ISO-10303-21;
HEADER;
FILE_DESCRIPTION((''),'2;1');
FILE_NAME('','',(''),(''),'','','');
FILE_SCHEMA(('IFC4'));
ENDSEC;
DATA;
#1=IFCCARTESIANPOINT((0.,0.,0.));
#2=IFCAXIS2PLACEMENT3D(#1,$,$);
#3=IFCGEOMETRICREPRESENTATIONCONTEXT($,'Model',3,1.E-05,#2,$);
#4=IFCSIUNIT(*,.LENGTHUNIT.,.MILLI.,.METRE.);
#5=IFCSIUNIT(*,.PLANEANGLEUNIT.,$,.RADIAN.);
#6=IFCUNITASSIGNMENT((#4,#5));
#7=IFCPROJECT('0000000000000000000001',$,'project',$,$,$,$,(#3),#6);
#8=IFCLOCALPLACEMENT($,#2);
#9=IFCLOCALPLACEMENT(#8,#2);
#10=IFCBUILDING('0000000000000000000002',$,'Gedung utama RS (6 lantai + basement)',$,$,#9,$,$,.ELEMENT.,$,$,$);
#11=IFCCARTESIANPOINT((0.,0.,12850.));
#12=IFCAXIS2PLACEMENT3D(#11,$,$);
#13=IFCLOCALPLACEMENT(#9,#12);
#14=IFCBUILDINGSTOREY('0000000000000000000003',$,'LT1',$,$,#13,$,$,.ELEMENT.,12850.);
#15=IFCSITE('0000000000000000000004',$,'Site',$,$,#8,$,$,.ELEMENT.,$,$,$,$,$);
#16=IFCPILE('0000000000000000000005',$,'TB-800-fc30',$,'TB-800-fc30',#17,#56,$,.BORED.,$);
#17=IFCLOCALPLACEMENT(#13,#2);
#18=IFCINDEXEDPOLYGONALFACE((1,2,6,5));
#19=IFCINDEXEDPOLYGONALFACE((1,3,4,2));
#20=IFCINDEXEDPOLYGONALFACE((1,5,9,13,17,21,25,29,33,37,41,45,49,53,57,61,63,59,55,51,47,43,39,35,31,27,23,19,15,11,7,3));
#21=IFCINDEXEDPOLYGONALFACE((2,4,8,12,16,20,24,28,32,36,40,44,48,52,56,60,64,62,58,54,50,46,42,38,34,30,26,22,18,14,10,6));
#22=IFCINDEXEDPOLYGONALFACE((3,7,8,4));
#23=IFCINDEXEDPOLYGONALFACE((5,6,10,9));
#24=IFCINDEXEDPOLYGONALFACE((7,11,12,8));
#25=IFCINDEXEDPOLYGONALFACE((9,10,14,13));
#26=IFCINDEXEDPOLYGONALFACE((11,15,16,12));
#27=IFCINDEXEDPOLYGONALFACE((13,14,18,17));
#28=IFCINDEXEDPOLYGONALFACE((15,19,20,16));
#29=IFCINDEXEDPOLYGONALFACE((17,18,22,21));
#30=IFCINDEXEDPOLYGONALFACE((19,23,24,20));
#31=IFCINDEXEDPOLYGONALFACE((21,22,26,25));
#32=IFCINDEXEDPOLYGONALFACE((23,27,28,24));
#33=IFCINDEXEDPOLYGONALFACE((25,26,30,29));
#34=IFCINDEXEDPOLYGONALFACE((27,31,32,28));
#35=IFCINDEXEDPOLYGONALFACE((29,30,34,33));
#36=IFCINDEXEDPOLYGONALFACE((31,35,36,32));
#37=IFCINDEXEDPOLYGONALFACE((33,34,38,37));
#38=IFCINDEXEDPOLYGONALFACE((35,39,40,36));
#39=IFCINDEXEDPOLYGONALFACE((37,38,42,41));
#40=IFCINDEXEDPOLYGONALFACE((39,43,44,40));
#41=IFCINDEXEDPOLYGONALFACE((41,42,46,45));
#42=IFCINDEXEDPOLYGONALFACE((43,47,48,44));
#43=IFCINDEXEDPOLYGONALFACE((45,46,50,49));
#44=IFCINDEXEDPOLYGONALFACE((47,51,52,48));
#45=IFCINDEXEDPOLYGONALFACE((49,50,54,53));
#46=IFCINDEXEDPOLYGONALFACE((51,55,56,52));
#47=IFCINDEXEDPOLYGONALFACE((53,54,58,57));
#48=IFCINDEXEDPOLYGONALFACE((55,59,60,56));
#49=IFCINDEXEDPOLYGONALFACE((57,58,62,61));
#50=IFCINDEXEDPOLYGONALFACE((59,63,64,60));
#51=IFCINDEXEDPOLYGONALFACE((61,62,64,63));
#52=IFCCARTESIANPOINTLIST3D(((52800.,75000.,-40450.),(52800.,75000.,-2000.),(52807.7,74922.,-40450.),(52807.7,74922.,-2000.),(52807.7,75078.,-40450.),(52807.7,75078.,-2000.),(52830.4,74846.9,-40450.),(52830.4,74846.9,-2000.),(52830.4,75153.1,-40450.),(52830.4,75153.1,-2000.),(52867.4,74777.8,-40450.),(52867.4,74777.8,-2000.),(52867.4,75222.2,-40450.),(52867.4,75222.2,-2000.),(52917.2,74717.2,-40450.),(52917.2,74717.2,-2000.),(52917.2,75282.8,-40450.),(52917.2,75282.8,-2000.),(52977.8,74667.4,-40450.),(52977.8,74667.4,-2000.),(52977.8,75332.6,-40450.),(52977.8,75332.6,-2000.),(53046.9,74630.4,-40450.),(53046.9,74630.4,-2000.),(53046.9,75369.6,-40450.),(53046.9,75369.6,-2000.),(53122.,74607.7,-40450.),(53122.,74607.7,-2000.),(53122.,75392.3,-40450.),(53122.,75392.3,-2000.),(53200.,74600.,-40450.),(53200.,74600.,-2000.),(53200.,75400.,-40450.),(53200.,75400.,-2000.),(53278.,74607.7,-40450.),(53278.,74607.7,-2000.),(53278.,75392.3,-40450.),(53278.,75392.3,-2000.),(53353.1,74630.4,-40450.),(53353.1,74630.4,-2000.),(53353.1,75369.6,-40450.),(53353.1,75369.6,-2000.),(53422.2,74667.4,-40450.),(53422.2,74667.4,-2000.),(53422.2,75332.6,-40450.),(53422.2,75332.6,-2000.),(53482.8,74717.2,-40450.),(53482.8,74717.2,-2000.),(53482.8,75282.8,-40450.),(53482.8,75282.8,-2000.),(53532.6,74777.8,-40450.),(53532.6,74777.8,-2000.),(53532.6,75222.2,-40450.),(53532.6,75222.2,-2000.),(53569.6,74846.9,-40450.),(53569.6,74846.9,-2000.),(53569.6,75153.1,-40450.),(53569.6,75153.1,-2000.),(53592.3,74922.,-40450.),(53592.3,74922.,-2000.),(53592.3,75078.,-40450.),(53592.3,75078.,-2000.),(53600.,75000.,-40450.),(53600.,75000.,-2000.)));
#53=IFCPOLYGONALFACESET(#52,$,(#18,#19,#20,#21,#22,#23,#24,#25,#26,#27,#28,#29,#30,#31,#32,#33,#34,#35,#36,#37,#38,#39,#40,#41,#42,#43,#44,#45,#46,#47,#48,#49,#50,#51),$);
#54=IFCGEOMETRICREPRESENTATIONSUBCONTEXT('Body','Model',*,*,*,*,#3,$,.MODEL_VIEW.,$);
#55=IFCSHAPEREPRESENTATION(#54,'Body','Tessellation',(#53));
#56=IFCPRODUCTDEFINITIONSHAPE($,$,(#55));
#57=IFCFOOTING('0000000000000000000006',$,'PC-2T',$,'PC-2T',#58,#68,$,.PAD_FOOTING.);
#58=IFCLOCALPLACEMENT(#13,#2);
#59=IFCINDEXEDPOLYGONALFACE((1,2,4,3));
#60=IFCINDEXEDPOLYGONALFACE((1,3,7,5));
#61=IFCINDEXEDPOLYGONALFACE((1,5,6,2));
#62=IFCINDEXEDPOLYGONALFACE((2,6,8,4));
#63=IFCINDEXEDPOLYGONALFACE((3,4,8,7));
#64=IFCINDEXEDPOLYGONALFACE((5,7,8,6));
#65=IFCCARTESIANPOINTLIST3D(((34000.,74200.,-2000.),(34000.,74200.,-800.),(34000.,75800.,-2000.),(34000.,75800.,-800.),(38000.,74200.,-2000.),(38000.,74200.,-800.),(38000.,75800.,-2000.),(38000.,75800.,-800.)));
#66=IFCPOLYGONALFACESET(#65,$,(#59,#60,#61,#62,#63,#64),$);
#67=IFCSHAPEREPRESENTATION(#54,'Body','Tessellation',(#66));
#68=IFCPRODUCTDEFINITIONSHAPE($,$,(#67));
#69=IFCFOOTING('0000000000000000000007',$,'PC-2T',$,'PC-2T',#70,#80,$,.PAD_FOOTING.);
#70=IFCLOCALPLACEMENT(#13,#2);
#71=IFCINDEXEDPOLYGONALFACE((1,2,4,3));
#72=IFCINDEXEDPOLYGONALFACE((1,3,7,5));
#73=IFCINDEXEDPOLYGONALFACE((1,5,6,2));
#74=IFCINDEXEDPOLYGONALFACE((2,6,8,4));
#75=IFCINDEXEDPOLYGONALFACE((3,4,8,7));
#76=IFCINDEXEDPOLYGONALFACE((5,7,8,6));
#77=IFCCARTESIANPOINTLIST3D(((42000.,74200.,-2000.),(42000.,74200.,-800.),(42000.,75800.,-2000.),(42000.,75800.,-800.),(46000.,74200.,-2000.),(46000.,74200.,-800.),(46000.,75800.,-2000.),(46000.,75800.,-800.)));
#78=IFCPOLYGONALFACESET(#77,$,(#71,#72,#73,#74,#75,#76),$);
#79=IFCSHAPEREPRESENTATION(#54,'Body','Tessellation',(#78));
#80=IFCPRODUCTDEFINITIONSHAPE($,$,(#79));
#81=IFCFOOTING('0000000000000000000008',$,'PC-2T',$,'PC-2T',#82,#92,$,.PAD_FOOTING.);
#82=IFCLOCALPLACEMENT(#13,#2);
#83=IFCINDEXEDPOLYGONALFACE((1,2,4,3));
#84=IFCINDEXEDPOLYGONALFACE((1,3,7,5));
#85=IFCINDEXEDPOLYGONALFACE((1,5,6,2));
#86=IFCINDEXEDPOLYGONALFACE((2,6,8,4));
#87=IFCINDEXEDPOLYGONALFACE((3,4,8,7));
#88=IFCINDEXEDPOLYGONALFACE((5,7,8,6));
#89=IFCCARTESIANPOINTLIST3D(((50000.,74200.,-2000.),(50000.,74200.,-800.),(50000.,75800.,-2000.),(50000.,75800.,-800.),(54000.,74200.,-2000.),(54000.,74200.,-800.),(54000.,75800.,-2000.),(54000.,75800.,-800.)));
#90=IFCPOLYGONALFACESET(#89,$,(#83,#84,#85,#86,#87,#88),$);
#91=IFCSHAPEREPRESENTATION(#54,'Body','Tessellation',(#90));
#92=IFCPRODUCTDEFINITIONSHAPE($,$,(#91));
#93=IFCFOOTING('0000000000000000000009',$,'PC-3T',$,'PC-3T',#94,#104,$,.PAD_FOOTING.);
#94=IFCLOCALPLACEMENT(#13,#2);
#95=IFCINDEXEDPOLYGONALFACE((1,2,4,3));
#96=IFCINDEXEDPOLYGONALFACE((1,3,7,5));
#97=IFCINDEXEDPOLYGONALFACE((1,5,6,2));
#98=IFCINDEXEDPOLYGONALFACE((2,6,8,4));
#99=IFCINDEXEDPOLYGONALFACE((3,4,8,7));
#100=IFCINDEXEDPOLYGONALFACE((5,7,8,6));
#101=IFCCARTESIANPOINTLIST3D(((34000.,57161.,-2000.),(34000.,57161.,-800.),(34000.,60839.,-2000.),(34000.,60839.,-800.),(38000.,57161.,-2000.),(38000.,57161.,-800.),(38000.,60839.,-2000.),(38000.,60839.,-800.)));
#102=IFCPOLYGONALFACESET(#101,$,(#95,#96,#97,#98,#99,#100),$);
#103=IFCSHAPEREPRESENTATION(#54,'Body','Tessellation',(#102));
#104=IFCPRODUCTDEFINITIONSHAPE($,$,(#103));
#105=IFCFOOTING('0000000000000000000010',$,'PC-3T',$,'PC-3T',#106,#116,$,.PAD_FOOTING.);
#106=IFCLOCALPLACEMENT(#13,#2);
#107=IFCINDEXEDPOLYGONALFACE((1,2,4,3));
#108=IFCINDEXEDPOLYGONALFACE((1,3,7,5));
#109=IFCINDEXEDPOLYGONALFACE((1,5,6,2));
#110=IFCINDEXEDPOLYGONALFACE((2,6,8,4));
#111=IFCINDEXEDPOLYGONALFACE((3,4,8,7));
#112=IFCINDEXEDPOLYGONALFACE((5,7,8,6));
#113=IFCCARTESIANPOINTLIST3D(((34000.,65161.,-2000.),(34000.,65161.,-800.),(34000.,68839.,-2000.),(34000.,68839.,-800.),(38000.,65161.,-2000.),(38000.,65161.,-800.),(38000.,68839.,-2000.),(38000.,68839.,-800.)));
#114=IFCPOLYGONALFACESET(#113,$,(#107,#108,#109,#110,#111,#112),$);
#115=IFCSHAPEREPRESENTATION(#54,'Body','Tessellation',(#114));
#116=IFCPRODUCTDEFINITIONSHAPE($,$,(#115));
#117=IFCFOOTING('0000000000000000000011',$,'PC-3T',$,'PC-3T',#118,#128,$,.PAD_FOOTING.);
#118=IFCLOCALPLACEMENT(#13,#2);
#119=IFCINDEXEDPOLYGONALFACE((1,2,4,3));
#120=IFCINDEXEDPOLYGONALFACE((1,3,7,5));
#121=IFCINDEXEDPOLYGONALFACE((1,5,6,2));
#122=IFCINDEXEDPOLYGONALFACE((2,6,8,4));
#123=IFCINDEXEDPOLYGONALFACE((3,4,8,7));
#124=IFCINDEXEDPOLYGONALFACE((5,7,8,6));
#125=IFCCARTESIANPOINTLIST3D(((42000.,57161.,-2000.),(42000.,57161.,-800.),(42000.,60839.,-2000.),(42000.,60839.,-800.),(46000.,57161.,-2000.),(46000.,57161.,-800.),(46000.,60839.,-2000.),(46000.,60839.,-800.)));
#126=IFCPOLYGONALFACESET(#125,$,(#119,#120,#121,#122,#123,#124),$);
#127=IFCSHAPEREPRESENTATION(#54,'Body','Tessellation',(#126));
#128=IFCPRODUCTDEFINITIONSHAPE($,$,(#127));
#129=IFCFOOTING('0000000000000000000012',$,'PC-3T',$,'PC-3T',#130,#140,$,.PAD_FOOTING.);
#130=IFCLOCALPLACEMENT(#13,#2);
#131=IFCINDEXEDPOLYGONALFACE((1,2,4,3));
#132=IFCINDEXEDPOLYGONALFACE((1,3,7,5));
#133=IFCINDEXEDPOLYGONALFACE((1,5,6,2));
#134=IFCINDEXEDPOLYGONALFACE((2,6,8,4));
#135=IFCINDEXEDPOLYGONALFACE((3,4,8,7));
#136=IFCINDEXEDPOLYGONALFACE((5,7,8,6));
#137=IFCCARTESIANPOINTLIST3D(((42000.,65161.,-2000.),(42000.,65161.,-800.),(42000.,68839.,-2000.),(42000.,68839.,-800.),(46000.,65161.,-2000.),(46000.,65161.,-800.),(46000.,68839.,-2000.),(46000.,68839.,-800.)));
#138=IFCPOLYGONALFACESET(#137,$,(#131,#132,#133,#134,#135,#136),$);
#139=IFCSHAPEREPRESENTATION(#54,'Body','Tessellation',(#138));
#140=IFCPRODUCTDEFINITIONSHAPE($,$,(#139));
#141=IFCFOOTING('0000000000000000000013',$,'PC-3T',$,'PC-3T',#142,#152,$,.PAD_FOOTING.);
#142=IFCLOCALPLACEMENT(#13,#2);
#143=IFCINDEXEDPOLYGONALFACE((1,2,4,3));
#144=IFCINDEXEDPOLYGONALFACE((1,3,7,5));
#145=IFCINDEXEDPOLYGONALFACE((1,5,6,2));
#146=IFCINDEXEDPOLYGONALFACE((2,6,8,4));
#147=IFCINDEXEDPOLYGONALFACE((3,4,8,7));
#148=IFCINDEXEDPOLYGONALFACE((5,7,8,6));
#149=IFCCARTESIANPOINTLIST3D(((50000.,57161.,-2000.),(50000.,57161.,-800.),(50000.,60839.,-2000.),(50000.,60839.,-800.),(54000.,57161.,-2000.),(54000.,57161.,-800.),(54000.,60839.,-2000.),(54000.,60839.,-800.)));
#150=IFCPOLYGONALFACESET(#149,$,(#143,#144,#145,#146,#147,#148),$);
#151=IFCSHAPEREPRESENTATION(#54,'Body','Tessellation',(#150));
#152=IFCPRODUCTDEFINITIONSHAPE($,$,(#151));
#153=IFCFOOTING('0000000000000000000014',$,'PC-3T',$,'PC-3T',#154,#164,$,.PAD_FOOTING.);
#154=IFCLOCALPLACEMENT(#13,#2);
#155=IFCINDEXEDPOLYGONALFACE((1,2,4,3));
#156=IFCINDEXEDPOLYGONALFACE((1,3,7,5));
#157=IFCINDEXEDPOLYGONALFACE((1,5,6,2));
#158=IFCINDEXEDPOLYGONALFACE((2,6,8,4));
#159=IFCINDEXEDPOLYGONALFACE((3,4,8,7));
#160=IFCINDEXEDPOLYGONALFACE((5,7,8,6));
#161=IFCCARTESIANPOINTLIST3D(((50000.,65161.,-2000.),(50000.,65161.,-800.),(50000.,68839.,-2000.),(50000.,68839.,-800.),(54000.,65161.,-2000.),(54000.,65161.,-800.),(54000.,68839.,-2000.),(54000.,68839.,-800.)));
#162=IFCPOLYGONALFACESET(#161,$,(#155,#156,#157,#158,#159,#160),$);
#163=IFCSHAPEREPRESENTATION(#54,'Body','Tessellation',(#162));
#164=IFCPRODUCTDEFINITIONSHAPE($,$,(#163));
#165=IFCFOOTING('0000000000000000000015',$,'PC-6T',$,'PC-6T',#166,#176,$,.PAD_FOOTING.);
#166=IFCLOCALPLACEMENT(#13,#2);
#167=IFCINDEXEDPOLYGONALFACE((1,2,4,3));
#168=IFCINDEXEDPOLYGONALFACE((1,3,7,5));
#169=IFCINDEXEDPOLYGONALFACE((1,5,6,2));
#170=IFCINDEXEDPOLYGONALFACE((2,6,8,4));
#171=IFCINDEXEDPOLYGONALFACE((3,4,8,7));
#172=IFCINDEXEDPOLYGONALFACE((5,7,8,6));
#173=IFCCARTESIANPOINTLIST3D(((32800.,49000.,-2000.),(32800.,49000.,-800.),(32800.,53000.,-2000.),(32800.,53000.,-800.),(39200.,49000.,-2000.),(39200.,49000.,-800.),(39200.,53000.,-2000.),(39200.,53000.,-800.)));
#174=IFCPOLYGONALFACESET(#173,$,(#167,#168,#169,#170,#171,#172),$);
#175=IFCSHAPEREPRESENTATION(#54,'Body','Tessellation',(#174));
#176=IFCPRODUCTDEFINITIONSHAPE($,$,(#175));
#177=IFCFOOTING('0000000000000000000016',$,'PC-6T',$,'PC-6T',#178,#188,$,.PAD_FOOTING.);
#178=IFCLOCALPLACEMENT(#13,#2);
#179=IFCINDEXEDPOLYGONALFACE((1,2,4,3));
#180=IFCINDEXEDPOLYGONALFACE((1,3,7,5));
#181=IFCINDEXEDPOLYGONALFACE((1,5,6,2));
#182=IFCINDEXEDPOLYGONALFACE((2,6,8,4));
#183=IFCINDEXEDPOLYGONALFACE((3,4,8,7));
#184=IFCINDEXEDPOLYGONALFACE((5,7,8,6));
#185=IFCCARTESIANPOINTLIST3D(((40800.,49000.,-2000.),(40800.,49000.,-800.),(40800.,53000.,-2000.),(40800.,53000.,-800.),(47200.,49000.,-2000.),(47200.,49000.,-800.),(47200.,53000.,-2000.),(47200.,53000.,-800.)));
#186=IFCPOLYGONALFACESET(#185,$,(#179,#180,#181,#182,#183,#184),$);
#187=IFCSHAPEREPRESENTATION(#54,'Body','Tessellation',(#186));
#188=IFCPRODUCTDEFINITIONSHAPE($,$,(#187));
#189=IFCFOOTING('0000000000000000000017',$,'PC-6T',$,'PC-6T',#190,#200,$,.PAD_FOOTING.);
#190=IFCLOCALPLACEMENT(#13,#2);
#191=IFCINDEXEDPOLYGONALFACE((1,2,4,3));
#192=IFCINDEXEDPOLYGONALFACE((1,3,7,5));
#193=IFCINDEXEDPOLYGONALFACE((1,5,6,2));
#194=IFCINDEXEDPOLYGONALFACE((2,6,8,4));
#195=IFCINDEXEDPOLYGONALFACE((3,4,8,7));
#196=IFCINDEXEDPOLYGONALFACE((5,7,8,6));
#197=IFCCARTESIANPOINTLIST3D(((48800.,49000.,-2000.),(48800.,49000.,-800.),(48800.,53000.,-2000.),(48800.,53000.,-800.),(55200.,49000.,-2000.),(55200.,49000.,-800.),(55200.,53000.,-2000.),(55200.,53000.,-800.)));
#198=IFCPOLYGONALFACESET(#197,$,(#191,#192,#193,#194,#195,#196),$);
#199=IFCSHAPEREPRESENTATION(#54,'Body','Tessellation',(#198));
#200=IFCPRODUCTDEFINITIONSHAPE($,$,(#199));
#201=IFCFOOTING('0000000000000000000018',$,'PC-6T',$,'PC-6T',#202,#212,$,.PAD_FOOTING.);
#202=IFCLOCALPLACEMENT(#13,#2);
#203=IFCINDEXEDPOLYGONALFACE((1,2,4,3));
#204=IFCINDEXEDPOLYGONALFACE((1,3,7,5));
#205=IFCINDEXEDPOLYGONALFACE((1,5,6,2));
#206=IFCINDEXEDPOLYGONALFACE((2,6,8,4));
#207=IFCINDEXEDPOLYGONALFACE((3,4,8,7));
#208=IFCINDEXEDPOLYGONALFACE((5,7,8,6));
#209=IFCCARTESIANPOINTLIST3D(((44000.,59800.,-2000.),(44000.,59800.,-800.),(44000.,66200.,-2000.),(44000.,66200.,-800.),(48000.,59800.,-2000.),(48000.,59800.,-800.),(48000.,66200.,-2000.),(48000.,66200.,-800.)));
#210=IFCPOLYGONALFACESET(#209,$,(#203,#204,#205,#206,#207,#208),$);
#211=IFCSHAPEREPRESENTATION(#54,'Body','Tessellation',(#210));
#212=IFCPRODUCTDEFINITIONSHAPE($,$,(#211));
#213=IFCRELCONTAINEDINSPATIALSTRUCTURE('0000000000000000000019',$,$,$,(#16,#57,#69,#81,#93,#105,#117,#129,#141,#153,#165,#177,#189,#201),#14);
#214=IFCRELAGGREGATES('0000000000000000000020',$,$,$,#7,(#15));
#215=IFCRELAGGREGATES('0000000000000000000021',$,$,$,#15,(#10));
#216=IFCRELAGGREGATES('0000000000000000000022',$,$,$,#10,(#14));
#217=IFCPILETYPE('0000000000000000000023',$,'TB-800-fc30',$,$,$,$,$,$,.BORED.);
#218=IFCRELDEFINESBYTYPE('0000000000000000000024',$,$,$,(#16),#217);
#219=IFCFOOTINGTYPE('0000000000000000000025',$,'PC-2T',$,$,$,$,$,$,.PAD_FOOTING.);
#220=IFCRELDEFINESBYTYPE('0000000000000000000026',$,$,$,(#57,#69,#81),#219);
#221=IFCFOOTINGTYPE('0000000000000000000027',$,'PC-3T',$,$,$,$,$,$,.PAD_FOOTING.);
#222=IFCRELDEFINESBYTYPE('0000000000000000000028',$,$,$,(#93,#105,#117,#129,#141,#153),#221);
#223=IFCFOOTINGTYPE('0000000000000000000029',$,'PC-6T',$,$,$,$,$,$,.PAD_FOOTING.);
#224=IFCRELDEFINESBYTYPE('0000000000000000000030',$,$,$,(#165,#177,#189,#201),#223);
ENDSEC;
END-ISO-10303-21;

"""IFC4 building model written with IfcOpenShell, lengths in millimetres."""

from ifc_helpers import new_model, si_unit, frame, origin, origin_2d, place, context, subcontext, project, spatial, rectangle, circle, extrude, material_profile, profile_set, profile_usage, type_object, element, save


model = new_model("IFC4")

# Units and contexts
model_context = context("Model", 3, precision=1e-05, world=origin())
body_context = subcontext(model_context, "Body", "Model", "MODEL_VIEW")
ifc_project = project(units=[si_unit("LENGTHUNIT", "METRE", prefix="MILLI"), si_unit("PLANEANGLEUNIT", "RADIAN")], contexts=[model_context])

# Site, building, storey
site_placement = place(None, origin())
site = spatial("IfcSite", under=ifc_project, at=site_placement, Name="Site", CompositionType="ELEMENT")
building_placement = place(site_placement, origin())
building = spatial("IfcBuilding", under=site, at=building_placement, Name="Gedung utama RS (6 lantai + basement)", CompositionType="ELEMENT")
storey_placement = place(building_placement, frame((0.0, 0.0, 12850.0)))
storey = spatial("IfcBuildingStorey", under=building, at=storey_placement, Name="LT1", CompositionType="ELEMENT", Elevation=12850.0)

# Pile
ifc_material_profile_1 = material_profile(None, circle(Radius=400.0, at=origin_2d()), Name="TB-800-fc30")
ifc_profile_set_1 = profile_set([ifc_material_profile_1], Name="TB-800-fc30")
ifc_profile_usage_1 = profile_usage(ifc_profile_set_1, cardinal=5)
pile_type = type_object("IfcPileType", Name="TB-800-fc30", PredefinedType="BORED", material=ifc_profile_set_1)
for number, where, z_axis, x_axis, name in (
    (1, (53200.0, 75000.0, -40450.0), (0.0, 0.0, 1.0), (1.0, 0.0, 0.0), "TB-800-fc30"),
):
    element("IfcPile", number, at=place(storey_placement, frame(where, z_axis=z_axis, x_axis=x_axis)), inside=storey, type_object=pile_type, material=ifc_profile_usage_1, Name=name, ObjectType="TB-800-fc30", PredefinedType="BORED", context=body_context, shape_type="SweptSolid", body=[
        extrude(circle(Radius=400.0, at=origin_2d()), origin(), (0.0, 0.0, 1.0), 38450.0),
    ])

# Footings
ifc_material_profile_2 = material_profile(None, rectangle(XDim=4000.0, YDim=1600.0, at=origin_2d()), Name="PC-2T")
ifc_profile_set_2 = profile_set([ifc_material_profile_2], Name="PC-2T")
ifc_profile_usage_2 = profile_usage(ifc_profile_set_2, cardinal=5)
footing_type_1 = type_object("IfcFootingType", Name="PC-2T", PredefinedType="PAD_FOOTING", material=ifc_profile_set_2)
for number, where, z_axis, x_axis, name in (
    (2, (36000.0, 75000.0, -2000.0), (0.0, 0.0, 1.0), (1.0, 0.0, 0.0), "PC-2T"),
    (3, (44000.0, 75000.0, -2000.0), (0.0, 0.0, 1.0), (1.0, 0.0, 0.0), "PC-2T"),
    (4, (52000.0, 75000.0, -2000.0), (0.0, 0.0, 1.0), (1.0, 0.0, 0.0), "PC-2T"),
):
    element("IfcFooting", number, at=place(storey_placement, frame(where, z_axis=z_axis, x_axis=x_axis)), inside=storey, type_object=footing_type_1, material=ifc_profile_usage_2, Name=name, ObjectType="PC-2T", PredefinedType="PAD_FOOTING", context=body_context, shape_type="SweptSolid", body=[
        extrude(rectangle(XDim=4000.0, YDim=1600.0, at=origin_2d()), origin(), (0.0, 0.0, 1.0), 1200.0),
    ])
ifc_material_profile_3 = material_profile(None, rectangle(XDim=4000.0, YDim=3678.0, at=origin_2d()), Name="PC-3T")
ifc_profile_set_3 = profile_set([ifc_material_profile_3], Name="PC-3T")
ifc_profile_usage_3 = profile_usage(ifc_profile_set_3, cardinal=5)
footing_type_2 = type_object("IfcFootingType", Name="PC-3T", PredefinedType="PAD_FOOTING", material=ifc_profile_set_3)
for number, where, z_axis, x_axis, name in (
    (5, (36000.0, 59000.0, -2000.0), (0.0, 0.0, 1.0), (1.0, 0.0, 0.0), "PC-3T"),
    (6, (36000.0, 67000.0, -2000.0), (0.0, 0.0, 1.0), (1.0, 0.0, 0.0), "PC-3T"),
    (7, (44000.0, 59000.0, -2000.0), (0.0, 0.0, 1.0), (1.0, 0.0, 0.0), "PC-3T"),
    (8, (44000.0, 67000.0, -2000.0), (0.0, 0.0, 1.0), (1.0, 0.0, 0.0), "PC-3T"),
    (9, (52000.0, 59000.0, -2000.0), (0.0, 0.0, 1.0), (1.0, 0.0, 0.0), "PC-3T"),
    (10, (52000.0, 67000.0, -2000.0), (0.0, 0.0, 1.0), (1.0, 0.0, 0.0), "PC-3T"),
):
    element("IfcFooting", number, at=place(storey_placement, frame(where, z_axis=z_axis, x_axis=x_axis)), inside=storey, type_object=footing_type_2, material=ifc_profile_usage_3, Name=name, ObjectType="PC-3T", PredefinedType="PAD_FOOTING", context=body_context, shape_type="SweptSolid", body=[
        extrude(rectangle(XDim=4000.0, YDim=3678.0, at=origin_2d()), origin(), (0.0, 0.0, 1.0), 1200.0),
    ])
ifc_material_profile_4 = material_profile(None, rectangle(XDim=6400.0, YDim=4000.0, at=origin_2d()), Name="PC-6T")
ifc_profile_set_4 = profile_set([ifc_material_profile_4], Name="PC-6T")
ifc_profile_usage_4 = profile_usage(ifc_profile_set_4, cardinal=5)
footing_type_3 = type_object("IfcFootingType", Name="PC-6T", PredefinedType="PAD_FOOTING", material=ifc_profile_set_4)
for number, where, z_axis, x_axis, name in (
    (11, (36000.0, 51000.0, -2000.0), (0.0, 0.0, 1.0), (1.0, 0.0, 0.0), "PC-6T"),
    (12, (44000.0, 51000.0, -2000.0), (0.0, 0.0, 1.0), (1.0, 0.0, 0.0), "PC-6T"),
    (13, (52000.0, 51000.0, -2000.0), (0.0, 0.0, 1.0), (1.0, 0.0, 0.0), "PC-6T"),
    (14, (46000.0, 63000.0, -2000.0), (0.0, 0.0, 1.0), (0.0, 1.0, 0.0), "PC-6T"),
):
    element("IfcFooting", number, at=place(storey_placement, frame(where, z_axis=z_axis, x_axis=x_axis)), inside=storey, type_object=footing_type_3, material=ifc_profile_usage_4, Name=name, ObjectType="PC-6T", PredefinedType="PAD_FOOTING", context=body_context, shape_type="SweptSolid", body=[
        extrude(rectangle(XDim=6400.0, YDim=4000.0, at=origin_2d()), origin(), (0.0, 0.0, 1.0), 1200.0),
    ])

save(model, "model.ifc")
